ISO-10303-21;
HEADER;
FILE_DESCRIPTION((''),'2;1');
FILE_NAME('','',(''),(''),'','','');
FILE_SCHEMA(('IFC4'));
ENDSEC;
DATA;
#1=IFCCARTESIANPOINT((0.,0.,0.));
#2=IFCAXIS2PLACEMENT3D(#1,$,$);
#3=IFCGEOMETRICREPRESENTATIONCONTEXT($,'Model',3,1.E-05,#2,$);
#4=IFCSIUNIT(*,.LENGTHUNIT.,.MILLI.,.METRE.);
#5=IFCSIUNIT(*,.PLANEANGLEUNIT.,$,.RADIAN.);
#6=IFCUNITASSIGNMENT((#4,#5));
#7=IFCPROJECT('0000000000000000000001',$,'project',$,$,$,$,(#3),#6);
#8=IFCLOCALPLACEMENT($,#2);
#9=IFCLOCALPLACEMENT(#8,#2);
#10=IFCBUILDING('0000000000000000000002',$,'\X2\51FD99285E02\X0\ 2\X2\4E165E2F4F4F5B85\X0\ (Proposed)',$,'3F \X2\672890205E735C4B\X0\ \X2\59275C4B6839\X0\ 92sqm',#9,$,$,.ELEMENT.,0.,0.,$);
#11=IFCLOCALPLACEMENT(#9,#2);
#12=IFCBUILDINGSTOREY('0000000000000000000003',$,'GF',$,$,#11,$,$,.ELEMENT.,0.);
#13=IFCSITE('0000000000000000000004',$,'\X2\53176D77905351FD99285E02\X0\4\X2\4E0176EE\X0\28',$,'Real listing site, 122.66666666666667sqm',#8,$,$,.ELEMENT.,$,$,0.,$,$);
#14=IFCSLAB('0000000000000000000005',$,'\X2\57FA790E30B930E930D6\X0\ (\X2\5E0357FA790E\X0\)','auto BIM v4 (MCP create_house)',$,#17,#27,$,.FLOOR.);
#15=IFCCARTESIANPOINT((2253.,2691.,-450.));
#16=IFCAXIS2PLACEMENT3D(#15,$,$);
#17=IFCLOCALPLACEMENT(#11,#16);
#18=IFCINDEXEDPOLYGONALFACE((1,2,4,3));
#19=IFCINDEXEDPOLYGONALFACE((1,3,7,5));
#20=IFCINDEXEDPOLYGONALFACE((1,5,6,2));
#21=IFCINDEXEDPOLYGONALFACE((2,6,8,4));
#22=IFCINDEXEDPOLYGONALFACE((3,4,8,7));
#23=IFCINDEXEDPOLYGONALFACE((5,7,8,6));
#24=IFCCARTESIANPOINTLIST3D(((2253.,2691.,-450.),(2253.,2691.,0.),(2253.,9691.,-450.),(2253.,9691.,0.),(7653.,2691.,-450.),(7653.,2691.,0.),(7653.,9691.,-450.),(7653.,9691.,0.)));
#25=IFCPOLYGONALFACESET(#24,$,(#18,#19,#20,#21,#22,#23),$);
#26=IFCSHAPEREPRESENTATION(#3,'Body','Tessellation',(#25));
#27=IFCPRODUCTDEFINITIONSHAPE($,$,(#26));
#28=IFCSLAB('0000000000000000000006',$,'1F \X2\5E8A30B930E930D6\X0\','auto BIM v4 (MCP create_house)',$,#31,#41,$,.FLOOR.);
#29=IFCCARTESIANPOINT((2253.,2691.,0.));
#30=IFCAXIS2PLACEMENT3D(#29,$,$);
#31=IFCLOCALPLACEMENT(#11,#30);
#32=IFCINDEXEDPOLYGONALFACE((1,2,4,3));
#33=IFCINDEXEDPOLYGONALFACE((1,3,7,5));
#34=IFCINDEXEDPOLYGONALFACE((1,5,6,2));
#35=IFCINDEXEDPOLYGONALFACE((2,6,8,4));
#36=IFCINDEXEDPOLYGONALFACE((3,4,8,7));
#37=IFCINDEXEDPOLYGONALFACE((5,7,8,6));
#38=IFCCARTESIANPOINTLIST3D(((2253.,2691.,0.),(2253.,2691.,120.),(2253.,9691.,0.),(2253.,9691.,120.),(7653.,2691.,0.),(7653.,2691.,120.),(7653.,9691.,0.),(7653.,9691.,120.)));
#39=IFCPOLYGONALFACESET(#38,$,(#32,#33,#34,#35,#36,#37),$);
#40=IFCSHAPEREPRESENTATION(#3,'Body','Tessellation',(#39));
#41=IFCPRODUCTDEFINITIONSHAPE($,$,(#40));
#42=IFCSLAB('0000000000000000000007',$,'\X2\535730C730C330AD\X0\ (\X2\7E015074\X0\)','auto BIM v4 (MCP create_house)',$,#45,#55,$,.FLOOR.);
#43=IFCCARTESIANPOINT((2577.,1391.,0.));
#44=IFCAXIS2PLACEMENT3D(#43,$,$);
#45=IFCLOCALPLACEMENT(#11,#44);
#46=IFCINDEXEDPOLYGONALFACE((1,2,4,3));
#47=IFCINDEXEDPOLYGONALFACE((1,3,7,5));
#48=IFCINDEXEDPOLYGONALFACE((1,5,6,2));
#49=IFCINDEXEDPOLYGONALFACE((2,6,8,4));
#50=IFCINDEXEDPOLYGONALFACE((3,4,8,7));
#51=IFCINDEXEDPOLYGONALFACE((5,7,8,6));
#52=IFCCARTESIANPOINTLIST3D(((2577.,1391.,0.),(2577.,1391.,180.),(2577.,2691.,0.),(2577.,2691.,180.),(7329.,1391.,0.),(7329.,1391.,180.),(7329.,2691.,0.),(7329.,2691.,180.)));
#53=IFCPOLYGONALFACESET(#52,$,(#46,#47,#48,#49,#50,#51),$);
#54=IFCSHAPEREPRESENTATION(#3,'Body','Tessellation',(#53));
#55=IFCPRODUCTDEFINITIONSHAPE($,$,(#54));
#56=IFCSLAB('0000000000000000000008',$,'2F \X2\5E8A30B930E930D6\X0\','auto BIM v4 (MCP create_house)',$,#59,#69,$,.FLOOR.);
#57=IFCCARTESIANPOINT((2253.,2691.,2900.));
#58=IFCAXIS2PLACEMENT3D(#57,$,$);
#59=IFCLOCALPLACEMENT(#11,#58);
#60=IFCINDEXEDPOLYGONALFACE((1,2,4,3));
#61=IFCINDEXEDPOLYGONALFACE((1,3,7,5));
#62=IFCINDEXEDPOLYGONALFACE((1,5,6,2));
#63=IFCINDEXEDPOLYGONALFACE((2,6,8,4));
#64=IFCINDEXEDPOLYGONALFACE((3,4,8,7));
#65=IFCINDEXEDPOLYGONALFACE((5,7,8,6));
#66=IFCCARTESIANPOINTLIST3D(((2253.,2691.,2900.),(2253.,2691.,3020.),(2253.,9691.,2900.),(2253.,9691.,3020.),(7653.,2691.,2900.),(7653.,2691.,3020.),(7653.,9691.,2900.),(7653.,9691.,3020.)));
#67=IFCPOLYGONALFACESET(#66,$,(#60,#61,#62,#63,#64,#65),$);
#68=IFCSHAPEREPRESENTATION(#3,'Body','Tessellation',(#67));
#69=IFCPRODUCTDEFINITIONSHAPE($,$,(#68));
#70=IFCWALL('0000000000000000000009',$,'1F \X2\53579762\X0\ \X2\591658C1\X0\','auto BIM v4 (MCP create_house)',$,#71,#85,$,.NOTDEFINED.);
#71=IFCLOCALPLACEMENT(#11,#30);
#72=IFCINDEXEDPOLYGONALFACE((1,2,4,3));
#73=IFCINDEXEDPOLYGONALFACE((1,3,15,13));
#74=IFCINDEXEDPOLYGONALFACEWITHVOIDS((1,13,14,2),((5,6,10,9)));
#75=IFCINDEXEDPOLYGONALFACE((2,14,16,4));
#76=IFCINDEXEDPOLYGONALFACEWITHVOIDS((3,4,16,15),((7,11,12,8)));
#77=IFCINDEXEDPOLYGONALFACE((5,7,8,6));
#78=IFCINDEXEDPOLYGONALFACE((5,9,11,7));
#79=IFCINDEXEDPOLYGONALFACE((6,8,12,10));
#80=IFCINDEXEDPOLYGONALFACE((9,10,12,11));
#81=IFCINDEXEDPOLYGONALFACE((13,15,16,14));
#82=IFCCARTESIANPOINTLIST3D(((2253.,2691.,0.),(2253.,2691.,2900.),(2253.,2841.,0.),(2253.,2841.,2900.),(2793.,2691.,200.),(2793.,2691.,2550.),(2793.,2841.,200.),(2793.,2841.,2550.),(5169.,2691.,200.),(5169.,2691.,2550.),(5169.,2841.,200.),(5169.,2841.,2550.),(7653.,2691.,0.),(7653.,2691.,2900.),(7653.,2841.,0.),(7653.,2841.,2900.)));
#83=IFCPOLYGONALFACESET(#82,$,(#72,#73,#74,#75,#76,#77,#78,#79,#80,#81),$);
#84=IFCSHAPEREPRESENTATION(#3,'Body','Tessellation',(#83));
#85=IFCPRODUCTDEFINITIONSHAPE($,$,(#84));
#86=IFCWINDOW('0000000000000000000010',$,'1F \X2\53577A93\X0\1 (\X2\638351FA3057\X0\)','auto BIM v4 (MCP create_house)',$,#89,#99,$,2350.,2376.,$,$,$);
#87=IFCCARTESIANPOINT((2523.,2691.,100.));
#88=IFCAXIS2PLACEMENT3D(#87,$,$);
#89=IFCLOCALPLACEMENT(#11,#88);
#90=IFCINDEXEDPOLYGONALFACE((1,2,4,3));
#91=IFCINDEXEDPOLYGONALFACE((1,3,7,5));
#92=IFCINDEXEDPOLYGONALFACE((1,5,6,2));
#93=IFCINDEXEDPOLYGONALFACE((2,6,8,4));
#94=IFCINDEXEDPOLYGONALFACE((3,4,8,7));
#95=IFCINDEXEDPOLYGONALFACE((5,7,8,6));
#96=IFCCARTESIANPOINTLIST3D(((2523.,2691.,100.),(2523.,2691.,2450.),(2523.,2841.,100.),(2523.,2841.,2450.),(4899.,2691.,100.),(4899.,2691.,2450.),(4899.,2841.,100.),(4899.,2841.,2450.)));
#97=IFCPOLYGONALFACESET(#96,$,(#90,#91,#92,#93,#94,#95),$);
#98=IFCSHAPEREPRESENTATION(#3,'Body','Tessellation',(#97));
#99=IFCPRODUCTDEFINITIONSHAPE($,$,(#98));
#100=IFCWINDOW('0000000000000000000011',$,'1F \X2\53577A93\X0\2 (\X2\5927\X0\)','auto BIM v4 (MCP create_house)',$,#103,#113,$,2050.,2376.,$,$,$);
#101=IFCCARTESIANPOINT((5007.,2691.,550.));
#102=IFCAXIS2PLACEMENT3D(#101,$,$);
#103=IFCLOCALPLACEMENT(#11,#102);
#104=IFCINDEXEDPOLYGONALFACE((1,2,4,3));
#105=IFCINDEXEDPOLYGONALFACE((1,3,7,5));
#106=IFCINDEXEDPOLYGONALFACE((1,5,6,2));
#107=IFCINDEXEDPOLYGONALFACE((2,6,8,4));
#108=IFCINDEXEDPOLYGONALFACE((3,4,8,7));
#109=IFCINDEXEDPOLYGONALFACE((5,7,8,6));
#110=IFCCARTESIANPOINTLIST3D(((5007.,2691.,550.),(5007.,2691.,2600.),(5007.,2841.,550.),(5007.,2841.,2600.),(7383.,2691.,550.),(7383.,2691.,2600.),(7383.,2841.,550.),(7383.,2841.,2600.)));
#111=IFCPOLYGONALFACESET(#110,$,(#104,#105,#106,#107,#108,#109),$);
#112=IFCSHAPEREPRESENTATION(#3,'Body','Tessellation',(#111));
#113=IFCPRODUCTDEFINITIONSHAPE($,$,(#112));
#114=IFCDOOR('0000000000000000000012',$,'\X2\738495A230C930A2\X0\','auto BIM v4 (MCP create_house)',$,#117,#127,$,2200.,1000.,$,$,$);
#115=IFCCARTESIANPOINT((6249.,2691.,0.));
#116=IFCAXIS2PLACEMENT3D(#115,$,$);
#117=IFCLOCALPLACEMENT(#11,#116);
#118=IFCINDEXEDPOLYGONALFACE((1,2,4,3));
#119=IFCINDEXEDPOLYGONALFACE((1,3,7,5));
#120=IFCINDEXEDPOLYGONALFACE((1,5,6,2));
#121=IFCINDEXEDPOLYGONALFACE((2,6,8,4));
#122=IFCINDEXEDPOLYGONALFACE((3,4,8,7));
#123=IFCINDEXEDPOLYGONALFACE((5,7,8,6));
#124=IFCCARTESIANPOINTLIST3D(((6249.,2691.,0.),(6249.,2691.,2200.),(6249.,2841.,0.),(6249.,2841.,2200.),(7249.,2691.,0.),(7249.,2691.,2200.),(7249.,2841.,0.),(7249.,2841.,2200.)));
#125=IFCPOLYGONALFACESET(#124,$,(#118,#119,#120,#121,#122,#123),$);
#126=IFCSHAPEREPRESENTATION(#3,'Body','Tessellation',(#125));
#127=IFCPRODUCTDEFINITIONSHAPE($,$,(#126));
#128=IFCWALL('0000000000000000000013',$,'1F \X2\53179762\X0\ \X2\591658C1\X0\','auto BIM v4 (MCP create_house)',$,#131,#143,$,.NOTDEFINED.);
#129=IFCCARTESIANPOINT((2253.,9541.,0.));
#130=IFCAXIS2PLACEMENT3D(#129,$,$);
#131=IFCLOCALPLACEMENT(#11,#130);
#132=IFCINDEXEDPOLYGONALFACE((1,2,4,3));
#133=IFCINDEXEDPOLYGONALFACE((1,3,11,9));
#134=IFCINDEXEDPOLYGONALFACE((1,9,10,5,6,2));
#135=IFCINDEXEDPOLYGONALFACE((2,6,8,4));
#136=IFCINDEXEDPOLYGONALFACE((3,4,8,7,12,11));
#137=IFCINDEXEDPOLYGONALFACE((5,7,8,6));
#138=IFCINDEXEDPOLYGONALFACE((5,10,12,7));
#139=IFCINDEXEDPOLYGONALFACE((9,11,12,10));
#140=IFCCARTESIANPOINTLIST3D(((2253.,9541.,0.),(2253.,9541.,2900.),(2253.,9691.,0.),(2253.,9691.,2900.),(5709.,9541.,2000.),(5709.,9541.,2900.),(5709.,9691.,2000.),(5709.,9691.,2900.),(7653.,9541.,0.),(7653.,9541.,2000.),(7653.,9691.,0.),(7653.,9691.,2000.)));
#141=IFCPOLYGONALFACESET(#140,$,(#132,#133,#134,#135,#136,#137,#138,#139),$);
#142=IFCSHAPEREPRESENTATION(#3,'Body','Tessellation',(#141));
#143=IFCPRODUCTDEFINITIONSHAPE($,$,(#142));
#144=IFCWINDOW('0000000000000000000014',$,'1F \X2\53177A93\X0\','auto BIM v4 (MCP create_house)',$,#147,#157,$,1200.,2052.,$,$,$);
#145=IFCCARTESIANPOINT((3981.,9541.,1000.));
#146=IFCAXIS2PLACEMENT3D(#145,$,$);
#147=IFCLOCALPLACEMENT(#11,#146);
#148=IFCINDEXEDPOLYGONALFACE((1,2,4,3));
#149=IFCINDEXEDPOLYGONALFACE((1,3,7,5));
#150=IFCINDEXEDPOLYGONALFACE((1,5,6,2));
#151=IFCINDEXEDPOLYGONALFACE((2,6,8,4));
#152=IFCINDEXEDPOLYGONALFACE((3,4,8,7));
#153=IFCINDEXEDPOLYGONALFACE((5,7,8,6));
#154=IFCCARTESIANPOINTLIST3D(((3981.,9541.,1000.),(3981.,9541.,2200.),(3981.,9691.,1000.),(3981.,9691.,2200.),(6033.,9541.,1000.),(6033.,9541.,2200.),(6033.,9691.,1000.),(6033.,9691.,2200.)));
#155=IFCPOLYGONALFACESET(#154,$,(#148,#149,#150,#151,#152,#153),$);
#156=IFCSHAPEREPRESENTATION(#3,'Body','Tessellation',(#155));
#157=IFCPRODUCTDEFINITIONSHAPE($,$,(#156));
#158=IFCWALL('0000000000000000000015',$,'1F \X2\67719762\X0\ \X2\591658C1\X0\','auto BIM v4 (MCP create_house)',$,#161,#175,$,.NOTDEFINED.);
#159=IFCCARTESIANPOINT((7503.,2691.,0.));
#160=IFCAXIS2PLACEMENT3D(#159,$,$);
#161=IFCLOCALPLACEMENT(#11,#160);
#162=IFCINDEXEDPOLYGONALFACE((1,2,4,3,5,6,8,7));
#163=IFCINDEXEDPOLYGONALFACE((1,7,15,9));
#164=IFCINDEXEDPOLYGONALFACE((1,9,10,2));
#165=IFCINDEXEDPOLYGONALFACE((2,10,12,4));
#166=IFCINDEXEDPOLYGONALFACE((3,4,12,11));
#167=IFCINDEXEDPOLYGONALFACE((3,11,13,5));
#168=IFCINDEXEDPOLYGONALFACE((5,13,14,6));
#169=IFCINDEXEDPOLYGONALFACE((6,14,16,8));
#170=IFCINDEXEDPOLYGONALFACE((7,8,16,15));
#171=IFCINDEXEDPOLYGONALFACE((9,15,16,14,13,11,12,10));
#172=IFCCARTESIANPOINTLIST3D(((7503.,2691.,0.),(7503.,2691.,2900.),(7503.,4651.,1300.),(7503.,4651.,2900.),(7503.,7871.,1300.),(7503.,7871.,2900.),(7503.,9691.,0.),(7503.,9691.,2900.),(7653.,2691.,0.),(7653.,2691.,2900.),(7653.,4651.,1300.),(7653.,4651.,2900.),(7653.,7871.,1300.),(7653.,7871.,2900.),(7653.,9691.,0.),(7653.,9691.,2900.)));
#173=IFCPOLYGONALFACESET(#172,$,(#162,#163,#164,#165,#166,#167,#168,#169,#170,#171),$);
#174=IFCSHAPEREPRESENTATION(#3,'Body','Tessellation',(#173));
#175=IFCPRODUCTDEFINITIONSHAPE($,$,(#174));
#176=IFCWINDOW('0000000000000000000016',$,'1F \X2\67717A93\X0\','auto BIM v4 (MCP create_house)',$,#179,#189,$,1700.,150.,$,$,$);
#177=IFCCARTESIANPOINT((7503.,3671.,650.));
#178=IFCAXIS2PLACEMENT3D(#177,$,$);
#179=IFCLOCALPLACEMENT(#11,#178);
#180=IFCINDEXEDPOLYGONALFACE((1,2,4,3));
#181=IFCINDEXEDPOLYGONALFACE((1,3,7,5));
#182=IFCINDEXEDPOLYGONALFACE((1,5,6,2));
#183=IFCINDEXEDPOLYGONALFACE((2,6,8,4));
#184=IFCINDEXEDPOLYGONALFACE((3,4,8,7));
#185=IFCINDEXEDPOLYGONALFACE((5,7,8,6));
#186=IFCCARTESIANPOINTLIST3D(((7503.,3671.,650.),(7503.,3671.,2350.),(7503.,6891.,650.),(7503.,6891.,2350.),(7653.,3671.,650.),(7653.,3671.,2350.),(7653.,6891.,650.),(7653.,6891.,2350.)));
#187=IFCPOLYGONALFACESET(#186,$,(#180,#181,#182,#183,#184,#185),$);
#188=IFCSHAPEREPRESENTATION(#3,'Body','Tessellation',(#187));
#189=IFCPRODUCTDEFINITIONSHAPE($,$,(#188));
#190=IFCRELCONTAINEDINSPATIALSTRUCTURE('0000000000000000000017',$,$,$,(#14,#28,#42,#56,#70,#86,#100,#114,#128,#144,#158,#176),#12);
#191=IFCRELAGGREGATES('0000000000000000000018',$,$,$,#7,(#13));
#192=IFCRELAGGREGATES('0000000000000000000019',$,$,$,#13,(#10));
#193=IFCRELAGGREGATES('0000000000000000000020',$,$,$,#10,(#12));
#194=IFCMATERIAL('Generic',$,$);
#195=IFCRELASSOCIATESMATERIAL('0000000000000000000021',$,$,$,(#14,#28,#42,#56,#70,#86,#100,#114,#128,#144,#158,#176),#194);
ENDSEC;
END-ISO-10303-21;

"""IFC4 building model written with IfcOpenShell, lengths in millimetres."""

from ifc_helpers import new_model, si_unit, frame, frame_2d, origin, place, context, project, spatial, rectangle, extrude, material, element, fill, save


model = new_model("IFC4")

# Units and contexts
model_context = context("Model", 3, precision=1e-05, world=origin())
ifc_project = project(units=[si_unit("LENGTHUNIT", "METRE", prefix="MILLI"), si_unit("PLANEANGLEUNIT", "RADIAN")], contexts=[model_context])

# Site, building, storey
site_placement = place(None, origin())
site = spatial("IfcSite", under=ifc_project, at=site_placement, Name="北海道函館市4丁目28", ObjectType="Real listing site, 122.66666666666667sqm", CompositionType="ELEMENT", RefElevation=0.0)
building_placement = place(site_placement, origin())
building = spatial("IfcBuilding", under=site, at=building_placement, Name="函館市 2世帯住宅 (Proposed)", ObjectType="3F 木造平屋 大屋根 92sqm", CompositionType="ELEMENT", ElevationOfRefHeight=0.0, ElevationOfTerrain=0.0)
storey_placement = place(building_placement, origin())
storey = spatial("IfcBuildingStorey", under=building, at=storey_placement, Name="GF", CompositionType="ELEMENT", Elevation=0.0)

# Slabs
ifc_material = material(Name="Generic")
slab_1_placement = place(storey_placement, frame((2253.0, 2691.0, -450.0)))
element("IfcSlab", 1, at=slab_1_placement, inside=storey, material=ifc_material, Name="基礎スラブ (布基礎)", Description="auto BIM v4 (MCP create_house)", PredefinedType="FLOOR", context=model_context, shape_type="SweptSolid", body=[
    extrude(rectangle(XDim=5400.0, YDim=7000.0, at=frame_2d((2700.0, 3500.0))), frame((2253.0, 2691.0, -450.0)), (0.0, 0.0, 1.0), 450.0),
])
slab_2_placement = place(storey_placement, frame((2253.0, 2691.0, 0.0)))
element("IfcSlab", 2, at=slab_2_placement, inside=storey, material=ifc_material, Name="1F 床スラブ", Description="auto BIM v4 (MCP create_house)", PredefinedType="FLOOR", context=model_context, shape_type="SweptSolid", body=[
    extrude(rectangle(XDim=5400.0, YDim=7000.0, at=frame_2d((2700.0, 3500.0))), frame((2253.0, 2691.0, 0.0)), (0.0, 0.0, 1.0), 120.0),
])
slab_3_placement = place(storey_placement, frame((2577.0, 1391.0, 0.0)))
element("IfcSlab", 3, at=slab_3_placement, inside=storey, material=ifc_material, Name="南デッキ (縁側)", Description="auto BIM v4 (MCP create_house)", PredefinedType="FLOOR", context=model_context, shape_type="SweptSolid", body=[
    extrude(rectangle(XDim=4752.0, YDim=1300.0, at=frame_2d((2376.0, 650.0))), frame((2577.0, 1391.0, 0.0)), (0.0, 0.0, 1.0), 180.0),
])
slab_4_placement = place(storey_placement, frame((2253.0, 2691.0, 2900.0)))
element("IfcSlab", 4, at=slab_4_placement, inside=storey, material=ifc_material, Name="2F 床スラブ", Description="auto BIM v4 (MCP create_house)", PredefinedType="FLOOR", context=model_context, shape_type="SweptSolid", body=[
    extrude(rectangle(XDim=5400.0, YDim=7000.0, at=frame_2d((2700.0, 3500.0))), frame((2253.0, 2691.0, 2900.0)), (0.0, 0.0, 1.0), 120.0),
])

# Wall, openings, windows, door
wall_1_placement = place(storey_placement, frame((2253.0, 2691.0, 0.0)))
wall_1 = element("IfcWall", 5, at=wall_1_placement, inside=storey, material=ifc_material, Name="1F 南面 外壁", Description="auto BIM v4 (MCP create_house)", PredefinedType="NOTDEFINED", context=model_context, shape_type="SweptSolid", body=[
    extrude(rectangle(XDim=5400.0, YDim=150.0, at=frame_2d((2700.0, 75.0))), frame((2253.0, 2691.0, 0.0)), (0.0, 0.0, 1.0), 2900.0),
])
opening_1_placement = place(storey_placement, frame((2523.0, 2691.0, 100.0)))
opening_1 = element("IfcOpeningElement", 6, at=opening_1_placement, cuts=wall_1, PredefinedType="NOTDEFINED", context=model_context, shape_type="SweptSolid", body=[
    extrude(rectangle(XDim=2376.0, YDim=150.0, at=frame_2d((1188.0, 75.0))), frame((2523.0, 2691.0, 100.0)), (0.0, 0.0, 1.0), 2350.0),
])
opening_2_placement = place(storey_placement, frame((5007.0, 2691.0, 550.0)))
opening_2 = element("IfcOpeningElement", 7, at=opening_2_placement, cuts=wall_1, PredefinedType="NOTDEFINED", context=model_context, shape_type="SweptSolid", body=[
    extrude(rectangle(XDim=2376.0, YDim=150.0, at=frame_2d((1188.0, 75.0))), frame((5007.0, 2691.0, 550.0)), (0.0, 0.0, 1.0), 2050.0),
])
opening_3_placement = place(storey_placement, frame((6249.0, 2691.0, 0.0)))
opening_3 = element("IfcOpeningElement", 8, at=opening_3_placement, cuts=wall_1, PredefinedType="NOTDEFINED", context=model_context, shape_type="SweptSolid", body=[
    extrude(rectangle(XDim=1000.0, YDim=150.0, at=frame_2d((500.0, 75.0))), frame((6249.0, 2691.0, 0.0)), (0.0, 0.0, 1.0), 2200.0),
])
window_1_placement = place(storey_placement, frame((2523.0, 2691.0, 100.0)))
window_1 = element("IfcWindow", 9, at=window_1_placement, inside=storey, material=ifc_material, Name="1F 南窓1 (掃出し)", Description="auto BIM v4 (MCP create_house)", OverallHeight=2350.0, OverallWidth=2376.0, context=model_context, shape_type="SweptSolid", body=[
    extrude(rectangle(XDim=2376.0, YDim=150.0, at=frame_2d((1188.0, 75.0))), frame((2523.0, 2691.0, 100.0)), (0.0, 0.0, 1.0), 2350.0),
])
fill(opening_1, window_1)
window_2_placement = place(storey_placement, frame((5007.0, 2691.0, 550.0)))
window_2 = element("IfcWindow", 10, at=window_2_placement, inside=storey, material=ifc_material, Name="1F 南窓2 (大)", Description="auto BIM v4 (MCP create_house)", OverallHeight=2050.0, OverallWidth=2376.0, context=model_context, shape_type="SweptSolid", body=[
    extrude(rectangle(XDim=2376.0, YDim=150.0, at=frame_2d((1188.0, 75.0))), frame((5007.0, 2691.0, 550.0)), (0.0, 0.0, 1.0), 2050.0),
])
fill(opening_2, window_2)
door_placement = place(storey_placement, frame((6249.0, 2691.0, 0.0)))
door = element("IfcDoor", 11, at=door_placement, inside=storey, material=ifc_material, Name="玄関ドア", Description="auto BIM v4 (MCP create_house)", OverallHeight=2200.0, OverallWidth=1000.0, context=model_context, shape_type="SweptSolid", body=[
    extrude(rectangle(XDim=1000.0, YDim=150.0, at=frame_2d((500.0, 75.0))), frame((6249.0, 2691.0, 0.0)), (0.0, 0.0, 1.0), 2200.0),
])
fill(opening_3, door)

# Walls, openings, windows
wall_2_placement = place(storey_placement, frame((2253.0, 9541.0, 0.0)))
wall_2 = element("IfcWall", 12, at=wall_2_placement, inside=storey, material=ifc_material, Name="1F 北面 外壁", Description="auto BIM v4 (MCP create_house)", PredefinedType="NOTDEFINED", context=model_context, shape_type="SweptSolid", body=[
    extrude(rectangle(XDim=5400.0, YDim=150.0, at=frame_2d((2700.0, 75.0))), frame((2253.0, 9541.0, 0.0)), (0.0, 0.0, 1.0), 2900.0),
])
opening_4_placement = place(storey_placement, frame((3981.0, 9541.0, 1000.0)))
opening_4 = element("IfcOpeningElement", 13, at=opening_4_placement, cuts=wall_2, PredefinedType="NOTDEFINED", context=model_context, shape_type="SweptSolid", body=[
    extrude(rectangle(XDim=2052.0, YDim=150.0, at=frame_2d((1026.0, 75.0))), frame((3981.0, 9541.0, 1000.0)), (0.0, 0.0, 1.0), 1200.0),
])
window_3_placement = place(storey_placement, frame((3981.0, 9541.0, 1000.0)))
window_3 = element("IfcWindow", 14, at=window_3_placement, inside=storey, material=ifc_material, Name="1F 北窓", Description="auto BIM v4 (MCP create_house)", OverallHeight=1200.0, OverallWidth=2052.0, context=model_context, shape_type="SweptSolid", body=[
    extrude(rectangle(XDim=2052.0, YDim=150.0, at=frame_2d((1026.0, 75.0))), frame((3981.0, 9541.0, 1000.0)), (0.0, 0.0, 1.0), 1200.0),
])
fill(opening_4, window_3)
wall_3_placement = place(storey_placement, frame((7503.0, 2691.0, 0.0)))
wall_3 = element("IfcWall", 15, at=wall_3_placement, inside=storey, material=ifc_material, Name="1F 東面 外壁", Description="auto BIM v4 (MCP create_house)", PredefinedType="NOTDEFINED", context=model_context, shape_type="SweptSolid", body=[
    extrude(rectangle(XDim=150.0, YDim=7000.0, at=frame_2d((75.0, 3500.0))), frame((7503.0, 2691.0, 0.0)), (0.0, 0.0, 1.0), 2900.0),
])
opening_5_placement = place(storey_placement, frame((7503.0, 3671.0, 650.0)))
opening_5 = element("IfcOpeningElement", 16, at=opening_5_placement, cuts=wall_3, PredefinedType="NOTDEFINED", context=model_context, shape_type="SweptSolid", body=[
    extrude(rectangle(XDim=150.0, YDim=3220.0, at=frame_2d((75.0, 1610.0))), frame((7503.0, 3671.0, 650.0)), (0.0, 0.0, 1.0), 1700.0),
])
window_4_placement = place(storey_placement, frame((7503.0, 3671.0, 650.0)))
window_4 = element("IfcWindow", 17, at=window_4_placement, inside=storey, material=ifc_material, Name="1F 東窓", Description="auto BIM v4 (MCP create_house)", OverallHeight=1700.0, OverallWidth=150.0, context=model_context, shape_type="SweptSolid", body=[
    extrude(rectangle(XDim=150.0, YDim=3220.0, at=frame_2d((75.0, 1610.0))), frame((7503.0, 3671.0, 650.0)), (0.0, 0.0, 1.0), 1700.0),
])
fill(opening_5, window_4)

save(model, "model.ifc")
